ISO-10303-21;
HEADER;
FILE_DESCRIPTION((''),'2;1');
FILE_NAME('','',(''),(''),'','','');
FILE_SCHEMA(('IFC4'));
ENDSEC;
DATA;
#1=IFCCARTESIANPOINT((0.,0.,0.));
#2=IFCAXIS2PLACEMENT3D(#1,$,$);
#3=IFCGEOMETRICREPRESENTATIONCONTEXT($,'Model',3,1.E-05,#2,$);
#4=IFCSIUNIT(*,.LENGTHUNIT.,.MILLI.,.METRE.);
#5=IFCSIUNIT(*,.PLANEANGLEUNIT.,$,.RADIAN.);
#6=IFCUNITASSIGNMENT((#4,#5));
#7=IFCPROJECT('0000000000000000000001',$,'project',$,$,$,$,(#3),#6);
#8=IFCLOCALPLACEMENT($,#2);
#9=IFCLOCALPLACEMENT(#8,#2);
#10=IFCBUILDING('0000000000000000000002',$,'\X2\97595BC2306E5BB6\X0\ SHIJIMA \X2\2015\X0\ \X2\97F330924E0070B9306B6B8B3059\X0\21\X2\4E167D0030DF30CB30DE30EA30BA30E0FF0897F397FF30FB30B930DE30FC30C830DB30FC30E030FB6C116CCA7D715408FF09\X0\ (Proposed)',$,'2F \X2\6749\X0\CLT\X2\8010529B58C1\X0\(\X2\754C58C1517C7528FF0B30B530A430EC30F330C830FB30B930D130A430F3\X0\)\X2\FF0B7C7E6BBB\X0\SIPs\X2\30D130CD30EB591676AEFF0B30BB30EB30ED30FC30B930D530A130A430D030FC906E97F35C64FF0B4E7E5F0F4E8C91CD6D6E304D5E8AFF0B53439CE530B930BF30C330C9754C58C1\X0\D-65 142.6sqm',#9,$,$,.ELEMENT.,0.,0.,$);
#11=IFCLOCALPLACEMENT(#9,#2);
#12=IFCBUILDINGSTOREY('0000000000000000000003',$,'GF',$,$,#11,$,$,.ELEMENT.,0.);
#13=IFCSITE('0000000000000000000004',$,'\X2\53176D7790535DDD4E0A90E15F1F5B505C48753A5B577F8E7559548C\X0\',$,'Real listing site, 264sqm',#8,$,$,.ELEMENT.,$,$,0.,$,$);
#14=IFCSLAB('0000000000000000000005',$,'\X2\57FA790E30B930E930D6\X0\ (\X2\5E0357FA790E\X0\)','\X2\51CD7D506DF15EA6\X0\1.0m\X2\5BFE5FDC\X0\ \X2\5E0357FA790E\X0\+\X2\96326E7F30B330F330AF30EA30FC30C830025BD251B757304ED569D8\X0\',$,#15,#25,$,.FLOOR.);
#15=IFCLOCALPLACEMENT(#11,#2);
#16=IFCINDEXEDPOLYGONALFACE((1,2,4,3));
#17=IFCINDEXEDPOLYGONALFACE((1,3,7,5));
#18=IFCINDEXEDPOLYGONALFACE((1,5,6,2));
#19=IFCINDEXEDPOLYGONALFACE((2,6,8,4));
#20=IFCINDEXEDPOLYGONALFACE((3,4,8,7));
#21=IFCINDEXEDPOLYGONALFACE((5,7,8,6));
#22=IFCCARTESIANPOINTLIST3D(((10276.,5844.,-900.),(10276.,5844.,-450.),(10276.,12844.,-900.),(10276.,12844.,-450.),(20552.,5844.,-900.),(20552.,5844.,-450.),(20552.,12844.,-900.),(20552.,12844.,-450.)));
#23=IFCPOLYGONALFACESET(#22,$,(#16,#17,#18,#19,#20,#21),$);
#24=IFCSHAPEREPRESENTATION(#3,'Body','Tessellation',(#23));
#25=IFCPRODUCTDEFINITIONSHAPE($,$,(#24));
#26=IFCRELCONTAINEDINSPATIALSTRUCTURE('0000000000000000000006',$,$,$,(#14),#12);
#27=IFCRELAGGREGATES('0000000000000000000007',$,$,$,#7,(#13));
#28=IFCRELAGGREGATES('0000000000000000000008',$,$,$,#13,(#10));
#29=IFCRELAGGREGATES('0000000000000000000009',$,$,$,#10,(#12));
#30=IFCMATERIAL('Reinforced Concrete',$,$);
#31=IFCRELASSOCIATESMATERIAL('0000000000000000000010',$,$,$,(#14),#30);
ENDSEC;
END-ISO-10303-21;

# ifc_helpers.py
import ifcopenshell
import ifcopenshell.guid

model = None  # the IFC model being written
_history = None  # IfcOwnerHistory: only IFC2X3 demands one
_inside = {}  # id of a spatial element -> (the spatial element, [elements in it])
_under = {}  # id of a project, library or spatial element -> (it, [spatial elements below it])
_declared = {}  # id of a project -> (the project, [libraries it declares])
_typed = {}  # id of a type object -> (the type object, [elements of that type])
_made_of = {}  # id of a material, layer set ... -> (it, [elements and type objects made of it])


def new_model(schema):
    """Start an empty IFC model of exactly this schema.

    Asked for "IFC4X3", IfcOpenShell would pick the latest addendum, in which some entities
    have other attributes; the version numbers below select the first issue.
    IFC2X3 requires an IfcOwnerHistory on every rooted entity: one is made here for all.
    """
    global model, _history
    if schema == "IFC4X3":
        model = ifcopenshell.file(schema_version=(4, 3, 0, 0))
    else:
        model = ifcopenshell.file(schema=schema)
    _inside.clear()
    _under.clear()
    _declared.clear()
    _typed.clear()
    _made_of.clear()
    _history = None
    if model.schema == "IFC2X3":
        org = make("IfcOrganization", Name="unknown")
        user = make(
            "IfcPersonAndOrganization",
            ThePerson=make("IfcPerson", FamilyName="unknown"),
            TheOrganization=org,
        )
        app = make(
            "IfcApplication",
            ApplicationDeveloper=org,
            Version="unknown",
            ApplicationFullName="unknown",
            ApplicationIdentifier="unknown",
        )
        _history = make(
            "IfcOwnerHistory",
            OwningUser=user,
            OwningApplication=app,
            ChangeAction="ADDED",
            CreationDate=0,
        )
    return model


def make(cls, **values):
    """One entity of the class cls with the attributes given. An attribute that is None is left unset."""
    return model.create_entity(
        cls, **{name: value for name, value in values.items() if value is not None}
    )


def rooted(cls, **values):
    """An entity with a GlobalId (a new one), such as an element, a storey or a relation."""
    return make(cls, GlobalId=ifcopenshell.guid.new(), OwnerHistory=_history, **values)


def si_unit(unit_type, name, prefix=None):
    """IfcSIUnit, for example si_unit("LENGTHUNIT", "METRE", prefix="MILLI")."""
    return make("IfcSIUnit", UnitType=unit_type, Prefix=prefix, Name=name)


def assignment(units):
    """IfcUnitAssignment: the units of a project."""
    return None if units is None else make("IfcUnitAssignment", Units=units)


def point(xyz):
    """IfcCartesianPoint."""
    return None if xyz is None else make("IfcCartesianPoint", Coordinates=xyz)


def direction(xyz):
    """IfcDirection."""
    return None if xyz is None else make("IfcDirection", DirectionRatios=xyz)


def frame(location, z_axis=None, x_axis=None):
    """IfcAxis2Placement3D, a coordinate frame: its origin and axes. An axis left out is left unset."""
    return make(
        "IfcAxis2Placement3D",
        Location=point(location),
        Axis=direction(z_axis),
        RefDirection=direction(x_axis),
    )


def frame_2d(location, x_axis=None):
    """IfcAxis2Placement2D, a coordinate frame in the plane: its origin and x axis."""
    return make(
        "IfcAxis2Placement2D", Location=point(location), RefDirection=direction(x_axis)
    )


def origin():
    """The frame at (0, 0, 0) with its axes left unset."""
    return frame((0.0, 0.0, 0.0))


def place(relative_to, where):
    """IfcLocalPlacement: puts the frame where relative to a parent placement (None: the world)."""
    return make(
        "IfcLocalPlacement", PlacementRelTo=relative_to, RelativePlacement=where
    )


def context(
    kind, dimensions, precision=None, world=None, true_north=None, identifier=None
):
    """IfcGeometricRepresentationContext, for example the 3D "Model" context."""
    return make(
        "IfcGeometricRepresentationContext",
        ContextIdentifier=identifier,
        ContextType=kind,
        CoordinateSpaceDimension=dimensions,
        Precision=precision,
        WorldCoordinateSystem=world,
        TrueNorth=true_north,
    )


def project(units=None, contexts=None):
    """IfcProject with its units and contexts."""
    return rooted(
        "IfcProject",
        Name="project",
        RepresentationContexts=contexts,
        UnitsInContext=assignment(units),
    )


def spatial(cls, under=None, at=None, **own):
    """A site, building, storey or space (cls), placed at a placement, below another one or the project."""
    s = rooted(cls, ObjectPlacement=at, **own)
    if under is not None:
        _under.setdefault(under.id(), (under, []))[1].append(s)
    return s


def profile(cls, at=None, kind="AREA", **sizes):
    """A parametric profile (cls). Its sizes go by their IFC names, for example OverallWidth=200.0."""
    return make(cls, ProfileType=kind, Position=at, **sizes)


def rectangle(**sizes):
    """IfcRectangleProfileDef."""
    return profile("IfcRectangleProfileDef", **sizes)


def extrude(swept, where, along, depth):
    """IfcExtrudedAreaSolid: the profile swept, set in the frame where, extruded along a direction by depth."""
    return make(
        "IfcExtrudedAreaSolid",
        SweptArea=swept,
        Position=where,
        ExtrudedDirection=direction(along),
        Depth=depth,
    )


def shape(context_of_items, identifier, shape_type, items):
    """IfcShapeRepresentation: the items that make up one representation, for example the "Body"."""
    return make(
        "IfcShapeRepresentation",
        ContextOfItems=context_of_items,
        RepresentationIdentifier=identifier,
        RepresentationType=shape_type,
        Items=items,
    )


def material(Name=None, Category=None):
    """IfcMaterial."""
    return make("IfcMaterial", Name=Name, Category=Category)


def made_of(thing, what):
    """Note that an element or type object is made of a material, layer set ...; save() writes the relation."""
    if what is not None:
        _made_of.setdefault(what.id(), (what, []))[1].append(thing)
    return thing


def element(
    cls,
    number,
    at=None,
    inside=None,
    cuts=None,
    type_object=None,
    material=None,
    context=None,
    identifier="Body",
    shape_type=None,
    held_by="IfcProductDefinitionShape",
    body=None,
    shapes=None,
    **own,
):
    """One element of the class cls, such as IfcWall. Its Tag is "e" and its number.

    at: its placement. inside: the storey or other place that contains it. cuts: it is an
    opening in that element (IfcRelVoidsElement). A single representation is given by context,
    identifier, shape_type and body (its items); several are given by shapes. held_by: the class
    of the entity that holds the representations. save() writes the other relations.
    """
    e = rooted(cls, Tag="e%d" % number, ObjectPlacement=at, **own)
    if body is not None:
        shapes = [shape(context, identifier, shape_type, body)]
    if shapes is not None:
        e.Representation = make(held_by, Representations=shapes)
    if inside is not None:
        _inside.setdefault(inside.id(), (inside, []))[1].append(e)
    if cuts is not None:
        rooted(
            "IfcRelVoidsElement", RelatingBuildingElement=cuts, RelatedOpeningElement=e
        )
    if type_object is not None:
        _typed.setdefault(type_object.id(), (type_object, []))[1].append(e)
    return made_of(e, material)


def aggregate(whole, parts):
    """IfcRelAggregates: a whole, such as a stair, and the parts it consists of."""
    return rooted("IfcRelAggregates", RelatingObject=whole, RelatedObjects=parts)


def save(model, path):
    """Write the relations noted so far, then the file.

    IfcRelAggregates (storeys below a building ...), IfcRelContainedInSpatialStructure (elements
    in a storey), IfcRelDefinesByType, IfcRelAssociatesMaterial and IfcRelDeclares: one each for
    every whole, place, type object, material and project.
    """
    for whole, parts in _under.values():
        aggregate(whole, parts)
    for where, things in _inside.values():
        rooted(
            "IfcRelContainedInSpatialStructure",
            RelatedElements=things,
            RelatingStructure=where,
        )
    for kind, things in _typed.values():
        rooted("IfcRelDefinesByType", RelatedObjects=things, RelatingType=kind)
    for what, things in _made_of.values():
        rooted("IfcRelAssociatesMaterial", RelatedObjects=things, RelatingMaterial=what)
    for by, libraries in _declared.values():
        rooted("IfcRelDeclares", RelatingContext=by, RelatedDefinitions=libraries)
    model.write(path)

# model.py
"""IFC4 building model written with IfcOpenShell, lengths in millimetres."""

from ifc_helpers import new_model, si_unit, frame, frame_2d, origin, place, context, project, spatial, rectangle, extrude, material, element, save


model = new_model("IFC4")

# Units and contexts
model_context = context("Model", 3, precision=1e-05, world=origin())
ifc_project = project(units=[si_unit("LENGTHUNIT", "METRE", prefix="MILLI"), si_unit("PLANEANGLEUNIT", "RADIAN")], contexts=[model_context])

# Site, building, storey
site_placement = place(None, origin())
site = spatial("IfcSite", under=ifc_project, at=site_placement, Name="北海道川上郡弟子屈町字美留和", ObjectType="Real listing site, 264sqm", CompositionType="ELEMENT", RefElevation=0.0)
building_placement = place(site_placement, origin())
building = spatial("IfcBuilding", under=site, at=building_placement, Name="静寂の家 SHIJIMA ― 音を一点に残す21世紀ミニマリズム（音響・スマートホーム・民泊統合） (Proposed)", ObjectType="2F 杉CLT耐力壁(界壁兼用＋サイレント・スパイン)＋籾殻SIPsパネル外皮＋セルロースファイバー遮音層＋乾式二重浮き床＋千鳥スタッド界壁D-65 142.6sqm", CompositionType="ELEMENT", ElevationOfRefHeight=0.0, ElevationOfTerrain=0.0)
storey_placement = place(building_placement, origin())
storey = spatial("IfcBuildingStorey", under=building, at=storey_placement, Name="GF", CompositionType="ELEMENT", Elevation=0.0)

# Slab
ifc_material_1 = material(Name="Reinforced Concrete")
slab_1_placement = place(storey_placement, frame((5138.0, 2922.0, -450.0)))
element("IfcSlab", 1, at=slab_1_placement, inside=storey, material=ifc_material_1, Name="基礎スラブ (布基礎)", Description="凍結深度1.0m対応 布基礎+防湿コンクリート。寒冷地仕様", PredefinedType="FLOOR", context=model_context, shape_type="SweptSolid", body=[
    extrude(rectangle(XDim=10276.0, YDim=7000.0, at=frame_2d((5138.0, 3500.0))), frame((5138.0, 2922.0, -450.0)), (0.0, 0.0, 1.0), 450.0),
])

save(model, "model.ifc")
